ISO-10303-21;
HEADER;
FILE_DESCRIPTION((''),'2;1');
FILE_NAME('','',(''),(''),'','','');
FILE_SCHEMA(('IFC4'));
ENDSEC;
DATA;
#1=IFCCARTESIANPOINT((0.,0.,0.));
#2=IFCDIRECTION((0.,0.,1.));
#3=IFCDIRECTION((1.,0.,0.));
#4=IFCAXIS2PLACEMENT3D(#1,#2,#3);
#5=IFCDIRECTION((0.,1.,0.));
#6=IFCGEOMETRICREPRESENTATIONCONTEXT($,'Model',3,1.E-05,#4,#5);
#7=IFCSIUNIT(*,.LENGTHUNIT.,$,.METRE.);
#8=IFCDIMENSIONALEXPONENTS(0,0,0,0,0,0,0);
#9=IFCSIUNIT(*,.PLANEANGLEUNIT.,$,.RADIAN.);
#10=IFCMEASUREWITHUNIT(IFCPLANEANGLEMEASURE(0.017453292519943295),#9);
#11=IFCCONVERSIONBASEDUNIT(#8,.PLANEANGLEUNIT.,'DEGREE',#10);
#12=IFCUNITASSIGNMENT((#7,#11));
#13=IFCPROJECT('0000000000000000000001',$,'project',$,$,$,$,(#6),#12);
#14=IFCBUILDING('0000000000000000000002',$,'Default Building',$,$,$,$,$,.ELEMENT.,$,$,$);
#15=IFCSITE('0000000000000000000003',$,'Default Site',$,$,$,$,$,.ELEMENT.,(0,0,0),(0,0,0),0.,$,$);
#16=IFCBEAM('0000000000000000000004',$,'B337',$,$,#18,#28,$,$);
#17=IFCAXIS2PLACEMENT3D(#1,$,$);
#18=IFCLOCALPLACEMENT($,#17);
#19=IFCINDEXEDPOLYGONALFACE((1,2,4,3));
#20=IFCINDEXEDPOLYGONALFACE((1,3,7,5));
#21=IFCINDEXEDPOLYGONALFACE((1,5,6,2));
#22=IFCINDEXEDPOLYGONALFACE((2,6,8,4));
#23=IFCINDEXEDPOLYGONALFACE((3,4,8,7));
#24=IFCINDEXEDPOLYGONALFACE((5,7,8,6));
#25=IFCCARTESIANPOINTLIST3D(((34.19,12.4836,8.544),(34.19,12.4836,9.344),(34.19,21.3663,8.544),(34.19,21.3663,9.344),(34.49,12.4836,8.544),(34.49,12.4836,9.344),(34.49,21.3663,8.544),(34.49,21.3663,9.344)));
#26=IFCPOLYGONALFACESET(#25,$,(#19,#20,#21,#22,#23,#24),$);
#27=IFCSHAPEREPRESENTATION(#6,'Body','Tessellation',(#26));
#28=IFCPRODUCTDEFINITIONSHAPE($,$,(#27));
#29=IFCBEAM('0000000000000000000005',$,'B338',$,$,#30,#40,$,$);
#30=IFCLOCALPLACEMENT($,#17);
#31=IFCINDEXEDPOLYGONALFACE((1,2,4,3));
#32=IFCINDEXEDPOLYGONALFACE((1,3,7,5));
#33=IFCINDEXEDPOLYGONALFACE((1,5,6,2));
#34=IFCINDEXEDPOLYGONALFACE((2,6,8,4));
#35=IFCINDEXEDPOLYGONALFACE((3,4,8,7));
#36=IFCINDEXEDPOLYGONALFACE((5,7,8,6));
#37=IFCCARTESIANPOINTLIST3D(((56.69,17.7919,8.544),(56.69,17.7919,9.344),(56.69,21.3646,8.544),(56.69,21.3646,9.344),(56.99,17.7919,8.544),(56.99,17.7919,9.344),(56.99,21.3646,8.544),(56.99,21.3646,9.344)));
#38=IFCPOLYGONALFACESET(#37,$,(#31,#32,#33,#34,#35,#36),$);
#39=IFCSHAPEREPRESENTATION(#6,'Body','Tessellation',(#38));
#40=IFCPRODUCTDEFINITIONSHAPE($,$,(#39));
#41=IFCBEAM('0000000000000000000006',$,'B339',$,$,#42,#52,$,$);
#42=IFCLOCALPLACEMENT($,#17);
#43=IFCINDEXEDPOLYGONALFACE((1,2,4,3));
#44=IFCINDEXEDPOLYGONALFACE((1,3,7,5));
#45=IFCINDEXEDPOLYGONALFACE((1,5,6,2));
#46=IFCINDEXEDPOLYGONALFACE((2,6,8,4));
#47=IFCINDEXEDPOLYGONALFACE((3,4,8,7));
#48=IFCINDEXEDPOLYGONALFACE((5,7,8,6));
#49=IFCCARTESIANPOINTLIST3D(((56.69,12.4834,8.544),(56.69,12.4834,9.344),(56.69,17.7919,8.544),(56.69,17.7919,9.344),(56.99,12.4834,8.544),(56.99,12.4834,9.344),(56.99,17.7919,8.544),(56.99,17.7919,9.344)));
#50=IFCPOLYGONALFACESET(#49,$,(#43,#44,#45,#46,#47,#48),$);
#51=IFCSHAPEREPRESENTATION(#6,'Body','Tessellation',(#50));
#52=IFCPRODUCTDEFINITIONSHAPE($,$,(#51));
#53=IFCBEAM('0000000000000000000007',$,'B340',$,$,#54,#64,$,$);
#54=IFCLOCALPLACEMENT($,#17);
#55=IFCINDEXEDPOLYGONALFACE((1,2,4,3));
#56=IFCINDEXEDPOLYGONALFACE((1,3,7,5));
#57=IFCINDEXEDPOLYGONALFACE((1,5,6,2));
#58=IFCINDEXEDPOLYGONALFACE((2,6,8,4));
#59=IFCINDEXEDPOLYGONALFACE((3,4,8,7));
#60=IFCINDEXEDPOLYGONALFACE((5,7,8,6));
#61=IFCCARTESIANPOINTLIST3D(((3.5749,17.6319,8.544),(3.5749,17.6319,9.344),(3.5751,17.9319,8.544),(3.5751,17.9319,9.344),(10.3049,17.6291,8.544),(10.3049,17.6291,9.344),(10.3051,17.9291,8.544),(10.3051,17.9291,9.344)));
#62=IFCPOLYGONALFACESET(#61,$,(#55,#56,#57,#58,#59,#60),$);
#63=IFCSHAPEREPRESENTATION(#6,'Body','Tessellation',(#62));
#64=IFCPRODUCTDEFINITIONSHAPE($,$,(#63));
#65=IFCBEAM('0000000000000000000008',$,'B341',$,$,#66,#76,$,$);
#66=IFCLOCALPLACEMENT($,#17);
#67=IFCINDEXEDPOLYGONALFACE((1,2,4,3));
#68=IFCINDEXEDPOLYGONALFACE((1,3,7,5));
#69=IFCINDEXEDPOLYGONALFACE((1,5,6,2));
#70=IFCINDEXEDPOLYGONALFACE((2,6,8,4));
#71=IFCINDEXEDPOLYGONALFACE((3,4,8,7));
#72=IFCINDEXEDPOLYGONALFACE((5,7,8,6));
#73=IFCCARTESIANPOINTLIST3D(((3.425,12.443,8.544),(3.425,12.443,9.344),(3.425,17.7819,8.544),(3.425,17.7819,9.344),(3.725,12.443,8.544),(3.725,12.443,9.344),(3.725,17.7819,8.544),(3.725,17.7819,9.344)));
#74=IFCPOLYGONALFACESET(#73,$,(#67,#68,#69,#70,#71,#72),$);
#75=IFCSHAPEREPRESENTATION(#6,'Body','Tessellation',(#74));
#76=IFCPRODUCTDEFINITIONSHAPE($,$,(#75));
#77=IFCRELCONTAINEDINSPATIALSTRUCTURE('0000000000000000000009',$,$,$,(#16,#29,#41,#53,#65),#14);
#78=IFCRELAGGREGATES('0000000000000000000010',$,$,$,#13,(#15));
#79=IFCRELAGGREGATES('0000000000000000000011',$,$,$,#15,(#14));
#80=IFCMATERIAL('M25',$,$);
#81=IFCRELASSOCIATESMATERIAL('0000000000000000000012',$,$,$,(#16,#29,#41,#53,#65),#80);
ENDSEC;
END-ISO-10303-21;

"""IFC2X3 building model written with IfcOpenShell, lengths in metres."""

from ifc_helpers import new_model, entity, si_unit, converted_unit, direction, frame, frame_2d, origin_with_axes, place, context, project, spatial, rectangle, extrude, material, element, save


model = new_model("IFC2X3")

# Units and contexts
model_context = context("Model", 3, precision=1e-05, world=origin_with_axes(), true_north=direction((0.0, 1.0, 0.0)))
ifc_project = project(units=[si_unit("LENGTHUNIT", "METRE"), converted_unit("PLANEANGLEUNIT", "DEGREE", entity("IfcPlaneAngleMeasure", 0.017453292519943295), si_unit("PLANEANGLEUNIT", "RADIAN"), dimensions=[0, 0, 0, 0, 0, 0, 0])], contexts=[model_context])

# Site, building
site = spatial("IfcSite", under=ifc_project, Name="Default Site", CompositionType="ELEMENT", RefLatitude=(0, 0, 0), RefLongitude=(0, 0, 0), RefElevation=0.0)
building = spatial("IfcBuilding", under=site, Name="Default Building", CompositionType="ELEMENT")

# Beams
ifc_material = material(Name="M25")
placement = place(None, origin_with_axes())
element("IfcBeam", 1, at=placement, inside=building, material=ifc_material, Name="B337", context=model_context, shape_type="SweptSolid", body=[
    extrude(rectangle(XDim=0.3, YDim=0.8, at=frame_2d((0.0, 0.0), x_axis=(0.0, 1.0, 0.0))), frame((34.34, 12.4836, 8.944), z_axis=(0.0, 1.0, 0.0), x_axis=(0.0, 0.0, -1.0)), (0.0, 0.0, 1.0), 8.8827),
])
element("IfcBeam", 2, at=placement, inside=building, material=ifc_material, Name="B338", context=model_context, shape_type="SweptSolid", body=[
    extrude(rectangle(XDim=0.3, YDim=0.8, at=frame_2d((0.0, 0.0), x_axis=(0.0, 1.0, 0.0))), frame((56.84, 17.7919, 8.944), z_axis=(0.0, 1.0, 0.0), x_axis=(0.0, 0.0, -1.0)), (0.0, 0.0, 1.0), 3.5727),
])
element("IfcBeam", 3, at=placement, inside=building, material=ifc_material, Name="B339", context=model_context, shape_type="SweptSolid", body=[
    extrude(rectangle(XDim=0.3, YDim=0.8, at=frame_2d((0.0, 0.0), x_axis=(0.0, 1.0, 0.0))), frame((56.84, 12.4834, 8.944), z_axis=(0.0, 1.0, 0.0), x_axis=(0.0, 0.0, -1.0)), (0.0, 0.0, 1.0), 5.3085),
])
element("IfcBeam", 4, at=placement, inside=building, material=ifc_material, Name="B340", context=model_context, shape_type="SweptSolid", body=[
    extrude(rectangle(XDim=0.3, YDim=0.8, at=frame_2d((0.0, 0.0), x_axis=(0.0, 1.0, 0.0))), frame((10.305, 17.7791, 8.944), z_axis=(-1.0, 0.000419, 0.0), x_axis=(0.0, 0.0, -1.0)), (0.0, 0.0, 1.0), 6.73),
])
element("IfcBeam", 5, at=placement, inside=building, material=ifc_material, Name="B341", context=model_context, shape_type="SweptSolid", body=[
    extrude(rectangle(XDim=0.3, YDim=0.8, at=frame_2d((0.0, 0.0), x_axis=(0.0, 1.0, 0.0))), frame((3.575, 12.443, 8.944), z_axis=(0.0, 1.0, 0.0), x_axis=(0.0, 0.0, -1.0)), (0.0, 0.0, 1.0), 5.3389),
])

save(model, "model.ifc")
